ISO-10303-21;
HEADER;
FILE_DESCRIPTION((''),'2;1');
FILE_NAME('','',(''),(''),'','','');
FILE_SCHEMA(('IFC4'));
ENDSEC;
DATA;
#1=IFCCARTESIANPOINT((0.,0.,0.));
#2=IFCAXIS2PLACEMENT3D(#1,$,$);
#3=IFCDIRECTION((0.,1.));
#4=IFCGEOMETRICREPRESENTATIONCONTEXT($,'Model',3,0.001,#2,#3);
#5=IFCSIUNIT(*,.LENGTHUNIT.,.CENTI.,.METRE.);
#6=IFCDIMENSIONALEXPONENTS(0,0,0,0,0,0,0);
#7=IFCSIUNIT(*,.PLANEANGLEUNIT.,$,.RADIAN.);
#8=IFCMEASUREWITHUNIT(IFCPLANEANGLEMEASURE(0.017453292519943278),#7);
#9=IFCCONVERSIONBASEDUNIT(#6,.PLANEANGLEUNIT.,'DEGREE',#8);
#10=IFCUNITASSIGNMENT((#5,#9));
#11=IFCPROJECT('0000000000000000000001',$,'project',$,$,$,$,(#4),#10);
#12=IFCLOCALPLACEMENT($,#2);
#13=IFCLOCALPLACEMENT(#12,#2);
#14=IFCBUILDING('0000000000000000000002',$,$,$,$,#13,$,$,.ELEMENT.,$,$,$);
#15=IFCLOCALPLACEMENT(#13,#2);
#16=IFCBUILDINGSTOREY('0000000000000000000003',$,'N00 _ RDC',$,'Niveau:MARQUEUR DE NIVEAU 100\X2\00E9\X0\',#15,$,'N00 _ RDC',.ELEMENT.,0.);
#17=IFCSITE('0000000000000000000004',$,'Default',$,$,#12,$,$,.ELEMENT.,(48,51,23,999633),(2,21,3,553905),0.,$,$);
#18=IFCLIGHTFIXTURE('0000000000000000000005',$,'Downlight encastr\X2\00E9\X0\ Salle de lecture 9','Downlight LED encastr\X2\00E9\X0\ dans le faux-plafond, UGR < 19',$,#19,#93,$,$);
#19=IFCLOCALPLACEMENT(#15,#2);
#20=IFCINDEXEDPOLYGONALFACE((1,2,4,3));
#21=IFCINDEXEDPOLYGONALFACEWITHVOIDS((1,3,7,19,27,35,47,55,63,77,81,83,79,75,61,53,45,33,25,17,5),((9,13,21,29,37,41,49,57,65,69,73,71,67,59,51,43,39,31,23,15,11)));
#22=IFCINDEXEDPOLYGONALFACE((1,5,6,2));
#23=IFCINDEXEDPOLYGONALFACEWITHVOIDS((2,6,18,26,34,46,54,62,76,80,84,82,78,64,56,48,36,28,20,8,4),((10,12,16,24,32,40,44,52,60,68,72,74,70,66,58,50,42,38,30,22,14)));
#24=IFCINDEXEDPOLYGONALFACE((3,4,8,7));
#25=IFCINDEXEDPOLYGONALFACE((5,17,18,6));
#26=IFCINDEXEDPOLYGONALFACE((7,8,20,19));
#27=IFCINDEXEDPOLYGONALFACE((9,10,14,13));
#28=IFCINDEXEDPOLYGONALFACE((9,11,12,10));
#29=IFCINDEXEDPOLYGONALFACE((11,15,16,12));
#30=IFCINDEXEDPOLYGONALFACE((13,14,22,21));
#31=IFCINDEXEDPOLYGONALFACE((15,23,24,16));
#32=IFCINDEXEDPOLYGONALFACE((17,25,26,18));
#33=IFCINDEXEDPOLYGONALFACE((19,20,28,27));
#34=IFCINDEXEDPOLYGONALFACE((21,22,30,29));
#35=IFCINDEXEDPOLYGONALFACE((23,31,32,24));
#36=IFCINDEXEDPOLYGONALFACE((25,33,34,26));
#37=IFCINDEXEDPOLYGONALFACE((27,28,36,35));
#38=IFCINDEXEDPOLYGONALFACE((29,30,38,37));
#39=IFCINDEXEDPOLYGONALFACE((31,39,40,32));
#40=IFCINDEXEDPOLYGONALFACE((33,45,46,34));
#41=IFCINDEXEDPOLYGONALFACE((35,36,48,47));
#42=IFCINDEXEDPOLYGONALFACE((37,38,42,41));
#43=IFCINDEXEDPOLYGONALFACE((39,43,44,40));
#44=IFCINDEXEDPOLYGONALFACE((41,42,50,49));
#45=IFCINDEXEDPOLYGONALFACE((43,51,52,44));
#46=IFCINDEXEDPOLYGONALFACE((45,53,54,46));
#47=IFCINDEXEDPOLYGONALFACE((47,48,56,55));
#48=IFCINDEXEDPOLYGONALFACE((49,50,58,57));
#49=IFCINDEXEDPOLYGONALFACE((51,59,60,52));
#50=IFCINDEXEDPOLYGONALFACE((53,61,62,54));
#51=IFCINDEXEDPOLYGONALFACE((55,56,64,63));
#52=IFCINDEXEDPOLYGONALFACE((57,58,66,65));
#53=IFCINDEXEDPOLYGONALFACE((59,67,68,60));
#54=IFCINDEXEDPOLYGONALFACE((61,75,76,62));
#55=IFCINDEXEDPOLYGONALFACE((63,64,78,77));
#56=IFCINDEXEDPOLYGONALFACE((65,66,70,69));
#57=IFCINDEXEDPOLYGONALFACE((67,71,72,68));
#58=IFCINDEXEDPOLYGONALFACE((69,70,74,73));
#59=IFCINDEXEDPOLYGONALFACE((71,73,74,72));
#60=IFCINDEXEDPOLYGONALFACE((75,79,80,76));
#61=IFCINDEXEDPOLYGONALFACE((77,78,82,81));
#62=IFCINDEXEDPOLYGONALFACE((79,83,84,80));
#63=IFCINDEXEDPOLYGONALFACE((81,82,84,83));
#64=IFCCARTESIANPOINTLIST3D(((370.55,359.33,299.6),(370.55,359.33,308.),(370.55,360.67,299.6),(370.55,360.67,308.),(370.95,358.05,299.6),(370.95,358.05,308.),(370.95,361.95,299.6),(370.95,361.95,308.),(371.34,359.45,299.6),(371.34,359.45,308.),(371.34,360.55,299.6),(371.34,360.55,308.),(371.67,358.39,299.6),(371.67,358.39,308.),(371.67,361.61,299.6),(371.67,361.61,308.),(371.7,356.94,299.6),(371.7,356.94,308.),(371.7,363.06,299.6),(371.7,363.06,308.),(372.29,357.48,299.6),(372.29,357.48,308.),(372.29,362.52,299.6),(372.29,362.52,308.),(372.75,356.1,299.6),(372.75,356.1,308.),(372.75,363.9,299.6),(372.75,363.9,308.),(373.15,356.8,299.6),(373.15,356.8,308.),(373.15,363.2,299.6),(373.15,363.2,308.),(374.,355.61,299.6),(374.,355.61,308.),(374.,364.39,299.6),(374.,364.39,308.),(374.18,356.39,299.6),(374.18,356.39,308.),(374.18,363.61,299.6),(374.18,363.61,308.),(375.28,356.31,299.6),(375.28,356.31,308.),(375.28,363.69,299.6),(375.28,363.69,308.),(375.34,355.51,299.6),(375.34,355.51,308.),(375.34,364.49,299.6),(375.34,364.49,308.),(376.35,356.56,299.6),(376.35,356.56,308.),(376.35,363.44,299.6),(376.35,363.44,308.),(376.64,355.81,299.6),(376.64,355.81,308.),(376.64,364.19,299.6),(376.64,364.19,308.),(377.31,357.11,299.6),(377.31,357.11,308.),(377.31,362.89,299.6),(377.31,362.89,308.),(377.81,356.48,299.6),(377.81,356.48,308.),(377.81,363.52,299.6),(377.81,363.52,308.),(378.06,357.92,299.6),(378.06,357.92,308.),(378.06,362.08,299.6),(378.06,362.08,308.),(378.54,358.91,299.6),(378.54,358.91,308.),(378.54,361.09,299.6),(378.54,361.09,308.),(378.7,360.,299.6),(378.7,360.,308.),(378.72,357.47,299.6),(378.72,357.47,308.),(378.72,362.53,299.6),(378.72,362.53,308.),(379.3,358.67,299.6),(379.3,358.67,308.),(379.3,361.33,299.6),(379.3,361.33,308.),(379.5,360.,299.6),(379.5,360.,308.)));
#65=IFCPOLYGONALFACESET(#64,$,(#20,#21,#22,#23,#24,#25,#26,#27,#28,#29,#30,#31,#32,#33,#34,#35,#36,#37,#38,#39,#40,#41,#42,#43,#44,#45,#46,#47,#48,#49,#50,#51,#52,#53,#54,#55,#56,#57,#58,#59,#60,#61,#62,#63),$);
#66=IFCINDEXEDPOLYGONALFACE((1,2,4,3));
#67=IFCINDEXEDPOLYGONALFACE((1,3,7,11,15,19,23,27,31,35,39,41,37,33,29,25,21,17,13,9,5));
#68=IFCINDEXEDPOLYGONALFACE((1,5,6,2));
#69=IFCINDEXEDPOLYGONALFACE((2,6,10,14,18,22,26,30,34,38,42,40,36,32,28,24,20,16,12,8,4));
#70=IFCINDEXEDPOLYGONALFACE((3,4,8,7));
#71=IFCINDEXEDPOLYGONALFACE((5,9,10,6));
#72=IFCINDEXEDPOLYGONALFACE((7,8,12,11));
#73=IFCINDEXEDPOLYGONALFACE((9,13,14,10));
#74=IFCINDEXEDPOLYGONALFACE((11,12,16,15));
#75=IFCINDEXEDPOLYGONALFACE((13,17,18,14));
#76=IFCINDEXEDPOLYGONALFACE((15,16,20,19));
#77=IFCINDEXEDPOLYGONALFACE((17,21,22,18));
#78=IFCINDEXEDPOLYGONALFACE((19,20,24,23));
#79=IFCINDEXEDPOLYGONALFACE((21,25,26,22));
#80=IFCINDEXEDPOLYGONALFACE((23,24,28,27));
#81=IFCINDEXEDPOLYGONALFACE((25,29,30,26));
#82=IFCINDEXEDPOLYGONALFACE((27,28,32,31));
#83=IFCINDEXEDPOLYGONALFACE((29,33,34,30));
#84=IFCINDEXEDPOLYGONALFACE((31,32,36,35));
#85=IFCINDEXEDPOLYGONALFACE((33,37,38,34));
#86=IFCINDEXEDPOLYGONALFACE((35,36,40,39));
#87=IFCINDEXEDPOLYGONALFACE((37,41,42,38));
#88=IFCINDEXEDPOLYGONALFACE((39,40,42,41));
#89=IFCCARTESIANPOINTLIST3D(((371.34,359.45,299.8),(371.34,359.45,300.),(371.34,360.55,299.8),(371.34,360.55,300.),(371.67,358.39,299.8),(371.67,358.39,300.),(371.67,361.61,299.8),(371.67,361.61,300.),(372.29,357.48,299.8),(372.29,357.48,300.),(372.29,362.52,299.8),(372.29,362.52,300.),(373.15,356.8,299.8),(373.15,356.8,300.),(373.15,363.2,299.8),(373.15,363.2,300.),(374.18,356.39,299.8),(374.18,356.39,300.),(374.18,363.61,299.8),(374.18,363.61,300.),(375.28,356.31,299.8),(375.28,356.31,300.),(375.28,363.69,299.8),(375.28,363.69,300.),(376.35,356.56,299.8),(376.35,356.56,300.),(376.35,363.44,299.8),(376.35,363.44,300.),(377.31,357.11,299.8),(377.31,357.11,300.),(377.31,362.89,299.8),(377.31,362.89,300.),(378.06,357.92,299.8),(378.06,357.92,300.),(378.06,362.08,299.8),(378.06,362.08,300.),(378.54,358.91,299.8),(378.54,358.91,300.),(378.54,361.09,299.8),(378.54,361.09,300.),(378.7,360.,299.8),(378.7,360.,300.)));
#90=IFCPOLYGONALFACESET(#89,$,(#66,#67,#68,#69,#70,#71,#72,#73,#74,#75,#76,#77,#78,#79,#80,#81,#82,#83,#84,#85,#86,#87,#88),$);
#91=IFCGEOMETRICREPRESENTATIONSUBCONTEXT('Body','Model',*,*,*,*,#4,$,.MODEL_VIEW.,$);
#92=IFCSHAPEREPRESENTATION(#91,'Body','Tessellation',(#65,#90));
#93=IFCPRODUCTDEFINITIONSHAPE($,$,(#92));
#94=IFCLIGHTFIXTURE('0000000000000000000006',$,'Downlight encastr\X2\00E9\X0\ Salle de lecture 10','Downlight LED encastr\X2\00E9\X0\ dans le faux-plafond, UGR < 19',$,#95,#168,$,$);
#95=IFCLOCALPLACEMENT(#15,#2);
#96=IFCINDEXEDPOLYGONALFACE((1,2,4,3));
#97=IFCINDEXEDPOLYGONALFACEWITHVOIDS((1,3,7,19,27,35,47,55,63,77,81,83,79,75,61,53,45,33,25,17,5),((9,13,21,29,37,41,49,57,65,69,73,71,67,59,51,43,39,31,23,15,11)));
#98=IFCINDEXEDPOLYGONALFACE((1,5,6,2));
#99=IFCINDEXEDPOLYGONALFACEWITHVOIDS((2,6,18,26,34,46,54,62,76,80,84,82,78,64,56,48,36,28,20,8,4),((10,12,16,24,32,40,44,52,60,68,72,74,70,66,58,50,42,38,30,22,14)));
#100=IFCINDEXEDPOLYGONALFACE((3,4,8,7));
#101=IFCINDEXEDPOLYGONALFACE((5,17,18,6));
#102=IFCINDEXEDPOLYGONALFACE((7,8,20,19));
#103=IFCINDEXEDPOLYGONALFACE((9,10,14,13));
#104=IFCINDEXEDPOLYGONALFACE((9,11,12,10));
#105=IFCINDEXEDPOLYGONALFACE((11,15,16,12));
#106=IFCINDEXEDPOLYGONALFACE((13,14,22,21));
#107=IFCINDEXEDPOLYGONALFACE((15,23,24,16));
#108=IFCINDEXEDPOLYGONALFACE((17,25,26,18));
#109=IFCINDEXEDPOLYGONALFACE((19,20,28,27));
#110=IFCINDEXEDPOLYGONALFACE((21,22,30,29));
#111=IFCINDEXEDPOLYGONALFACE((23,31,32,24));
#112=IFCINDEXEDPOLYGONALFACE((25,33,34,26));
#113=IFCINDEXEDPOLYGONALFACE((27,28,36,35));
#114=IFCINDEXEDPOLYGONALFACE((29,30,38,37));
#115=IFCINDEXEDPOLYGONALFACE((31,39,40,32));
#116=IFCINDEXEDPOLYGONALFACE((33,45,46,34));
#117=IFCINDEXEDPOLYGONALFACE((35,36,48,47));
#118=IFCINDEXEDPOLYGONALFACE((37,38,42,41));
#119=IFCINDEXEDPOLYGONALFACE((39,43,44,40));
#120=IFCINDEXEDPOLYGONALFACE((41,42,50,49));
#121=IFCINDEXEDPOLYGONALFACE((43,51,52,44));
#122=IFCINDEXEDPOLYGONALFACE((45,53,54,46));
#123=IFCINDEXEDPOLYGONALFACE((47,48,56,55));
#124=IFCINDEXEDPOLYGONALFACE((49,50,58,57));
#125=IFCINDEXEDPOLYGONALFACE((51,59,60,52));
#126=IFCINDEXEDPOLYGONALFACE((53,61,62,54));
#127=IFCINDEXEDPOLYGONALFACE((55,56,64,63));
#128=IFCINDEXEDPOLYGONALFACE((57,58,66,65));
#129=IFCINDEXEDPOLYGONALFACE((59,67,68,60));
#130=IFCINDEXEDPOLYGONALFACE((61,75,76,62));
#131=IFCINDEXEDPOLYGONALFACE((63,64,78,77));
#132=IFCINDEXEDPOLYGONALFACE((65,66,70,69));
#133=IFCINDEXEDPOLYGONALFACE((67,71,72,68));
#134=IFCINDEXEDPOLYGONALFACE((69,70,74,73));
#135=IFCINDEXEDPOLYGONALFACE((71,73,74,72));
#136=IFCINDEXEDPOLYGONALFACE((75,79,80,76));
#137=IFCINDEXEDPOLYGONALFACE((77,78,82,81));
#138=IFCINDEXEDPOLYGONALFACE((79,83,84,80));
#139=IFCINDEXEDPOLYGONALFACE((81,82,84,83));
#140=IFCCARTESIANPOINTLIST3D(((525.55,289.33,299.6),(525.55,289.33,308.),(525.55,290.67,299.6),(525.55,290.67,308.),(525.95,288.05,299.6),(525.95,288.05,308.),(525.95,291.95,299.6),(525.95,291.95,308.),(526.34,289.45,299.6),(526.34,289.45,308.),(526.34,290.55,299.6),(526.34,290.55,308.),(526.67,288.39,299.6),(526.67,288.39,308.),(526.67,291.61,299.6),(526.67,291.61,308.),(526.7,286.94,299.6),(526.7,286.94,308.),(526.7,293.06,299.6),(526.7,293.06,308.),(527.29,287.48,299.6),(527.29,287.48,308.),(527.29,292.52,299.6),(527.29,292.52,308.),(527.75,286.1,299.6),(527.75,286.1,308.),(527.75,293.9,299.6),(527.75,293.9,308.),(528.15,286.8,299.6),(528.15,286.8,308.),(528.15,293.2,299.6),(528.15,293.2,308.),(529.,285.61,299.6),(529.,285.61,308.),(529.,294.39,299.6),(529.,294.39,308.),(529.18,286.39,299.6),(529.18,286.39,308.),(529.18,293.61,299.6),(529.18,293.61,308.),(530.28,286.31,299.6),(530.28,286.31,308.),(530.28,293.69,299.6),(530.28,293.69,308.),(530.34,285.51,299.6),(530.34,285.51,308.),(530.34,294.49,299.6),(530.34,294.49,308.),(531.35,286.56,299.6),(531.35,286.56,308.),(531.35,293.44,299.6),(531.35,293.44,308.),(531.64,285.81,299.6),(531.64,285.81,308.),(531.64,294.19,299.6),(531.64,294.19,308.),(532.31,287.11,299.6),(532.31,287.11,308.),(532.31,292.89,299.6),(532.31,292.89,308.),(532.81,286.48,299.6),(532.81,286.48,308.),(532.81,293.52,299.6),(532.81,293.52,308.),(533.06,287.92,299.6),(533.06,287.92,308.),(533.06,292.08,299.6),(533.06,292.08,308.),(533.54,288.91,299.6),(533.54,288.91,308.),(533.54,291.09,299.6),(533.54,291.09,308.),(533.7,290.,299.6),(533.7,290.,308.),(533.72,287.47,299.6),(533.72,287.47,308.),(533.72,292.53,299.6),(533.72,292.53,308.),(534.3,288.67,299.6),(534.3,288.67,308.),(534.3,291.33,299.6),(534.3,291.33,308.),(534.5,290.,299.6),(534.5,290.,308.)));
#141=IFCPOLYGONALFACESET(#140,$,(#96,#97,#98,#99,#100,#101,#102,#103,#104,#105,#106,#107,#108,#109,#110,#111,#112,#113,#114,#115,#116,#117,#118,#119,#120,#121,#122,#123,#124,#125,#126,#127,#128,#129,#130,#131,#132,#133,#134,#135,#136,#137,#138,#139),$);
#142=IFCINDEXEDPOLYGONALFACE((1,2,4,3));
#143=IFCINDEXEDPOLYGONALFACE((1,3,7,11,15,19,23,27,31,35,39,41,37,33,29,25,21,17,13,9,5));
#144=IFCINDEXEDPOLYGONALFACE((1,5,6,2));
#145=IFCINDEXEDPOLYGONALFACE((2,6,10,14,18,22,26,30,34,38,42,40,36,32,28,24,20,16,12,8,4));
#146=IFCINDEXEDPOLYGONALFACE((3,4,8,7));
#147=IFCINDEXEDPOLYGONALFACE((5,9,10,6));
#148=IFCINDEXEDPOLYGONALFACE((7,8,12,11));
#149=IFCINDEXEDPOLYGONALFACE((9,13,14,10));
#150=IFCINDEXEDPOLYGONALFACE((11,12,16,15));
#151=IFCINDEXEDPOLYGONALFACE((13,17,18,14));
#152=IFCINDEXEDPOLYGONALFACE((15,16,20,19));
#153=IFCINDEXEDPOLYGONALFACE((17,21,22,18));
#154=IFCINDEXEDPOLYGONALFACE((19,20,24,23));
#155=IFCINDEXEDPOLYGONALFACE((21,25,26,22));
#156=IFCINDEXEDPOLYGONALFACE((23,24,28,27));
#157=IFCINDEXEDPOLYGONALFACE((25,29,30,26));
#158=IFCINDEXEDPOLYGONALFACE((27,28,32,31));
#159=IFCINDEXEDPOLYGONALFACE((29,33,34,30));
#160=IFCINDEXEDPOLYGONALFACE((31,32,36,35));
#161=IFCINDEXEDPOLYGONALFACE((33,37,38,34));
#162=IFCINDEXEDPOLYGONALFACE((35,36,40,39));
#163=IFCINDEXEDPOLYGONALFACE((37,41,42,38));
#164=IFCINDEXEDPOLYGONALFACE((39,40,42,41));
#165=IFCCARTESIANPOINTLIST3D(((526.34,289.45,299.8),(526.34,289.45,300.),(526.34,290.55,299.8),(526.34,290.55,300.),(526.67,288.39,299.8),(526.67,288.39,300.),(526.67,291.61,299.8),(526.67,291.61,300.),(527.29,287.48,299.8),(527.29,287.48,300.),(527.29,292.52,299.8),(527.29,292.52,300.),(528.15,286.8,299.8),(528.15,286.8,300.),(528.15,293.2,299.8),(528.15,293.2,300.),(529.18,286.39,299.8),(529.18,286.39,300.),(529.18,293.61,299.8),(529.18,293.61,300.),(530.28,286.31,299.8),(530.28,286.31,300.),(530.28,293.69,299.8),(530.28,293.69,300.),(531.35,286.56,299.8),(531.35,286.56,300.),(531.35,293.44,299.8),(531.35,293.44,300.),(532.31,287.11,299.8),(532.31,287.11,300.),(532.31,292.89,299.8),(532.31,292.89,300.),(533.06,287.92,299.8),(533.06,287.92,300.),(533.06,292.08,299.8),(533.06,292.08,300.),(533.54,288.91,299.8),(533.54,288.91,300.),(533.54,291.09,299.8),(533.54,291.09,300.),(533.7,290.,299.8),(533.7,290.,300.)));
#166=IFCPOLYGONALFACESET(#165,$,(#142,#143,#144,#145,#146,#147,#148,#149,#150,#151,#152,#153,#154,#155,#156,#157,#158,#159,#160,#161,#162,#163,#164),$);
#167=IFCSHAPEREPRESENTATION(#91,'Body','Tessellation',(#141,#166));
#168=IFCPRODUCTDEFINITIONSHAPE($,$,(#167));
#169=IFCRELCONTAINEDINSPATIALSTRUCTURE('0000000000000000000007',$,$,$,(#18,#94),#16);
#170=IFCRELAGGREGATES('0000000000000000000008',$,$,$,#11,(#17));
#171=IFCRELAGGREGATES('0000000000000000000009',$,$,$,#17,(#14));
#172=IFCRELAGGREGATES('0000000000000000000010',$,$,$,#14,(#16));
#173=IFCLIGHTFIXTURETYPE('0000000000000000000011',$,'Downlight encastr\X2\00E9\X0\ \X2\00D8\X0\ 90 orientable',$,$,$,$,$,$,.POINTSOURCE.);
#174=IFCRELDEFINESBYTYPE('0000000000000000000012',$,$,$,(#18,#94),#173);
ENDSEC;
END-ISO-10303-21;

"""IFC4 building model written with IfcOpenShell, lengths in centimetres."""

from ifc_helpers import new_model, entity, si_unit, converted_unit, direction, frame, frame_2d, origin, origin_with_axes, place, context, subcontext, project, spatial, circle, hollow_circle, extrude, type_object, element, save


model = new_model("IFC4")

# Units and contexts
model_context = context("Model", 3, precision=0.001, world=origin(), true_north=direction((0.0, 1.0)))
body_context = subcontext(model_context, "Body", "Model", "MODEL_VIEW")
ifc_project = project(units=[si_unit("LENGTHUNIT", "METRE", prefix="CENTI"), converted_unit("PLANEANGLEUNIT", "DEGREE", entity("IfcPlaneAngleMeasure", 0.017453292519943278), si_unit("PLANEANGLEUNIT", "RADIAN"), dimensions=[0, 0, 0, 0, 0, 0, 0])], contexts=[model_context])

# Site, building, storey
site_placement = place(None, origin())
site = spatial("IfcSite", under=ifc_project, at=site_placement, Name="Default", CompositionType="ELEMENT", RefLatitude=(48, 51, 23, 999633), RefLongitude=(2, 21, 3, 553905), RefElevation=0.0)
building_placement = place(site_placement, origin())
building = spatial("IfcBuilding", under=site, at=building_placement, CompositionType="ELEMENT")
storey_placement = place(building_placement, origin())
storey = spatial("IfcBuildingStorey", under=building, at=storey_placement, Name="N00 _ RDC", ObjectType="Niveau:MARQUEUR DE NIVEAU 100é", LongName="N00 _ RDC", CompositionType="ELEMENT", Elevation=0.0)

# Light fixtures
light_fixture_type_1 = type_object("IfcLightFixtureType", Name="Downlight encastré Ø 90 orientable", PredefinedType="POINTSOURCE")
light_fixture_1_placement = place(storey_placement, origin_with_axes())
element("IfcLightFixture", 1, at=light_fixture_1_placement, inside=storey, type_object=light_fixture_type_1, Name="Downlight encastré Salle de lecture 9", Description="Downlight LED encastré dans le faux-plafond, UGR < 19", context=body_context, shape_type="SweptSolid", body=[
    extrude(hollow_circle(Radius=4.5, WallThickness=0.8, at=frame_2d((375.0, 360.0))), frame((0.0, 0.0, 299.6)), (0.0, 0.0, 1.0), 8.4),
    extrude(circle(Radius=3.7, at=frame_2d((375.0, 360.0))), frame((0.0, 0.0, 299.8)), (0.0, 0.0, 1.0), 0.2),
])
light_fixture_2_placement = place(storey_placement, origin_with_axes())
element("IfcLightFixture", 2, at=light_fixture_2_placement, inside=storey, type_object=light_fixture_type_1, Name="Downlight encastré Salle de lecture 10", Description="Downlight LED encastré dans le faux-plafond, UGR < 19", context=body_context, shape_type="SweptSolid", body=[
    extrude(hollow_circle(Radius=4.5, WallThickness=0.8, at=frame_2d((530.0, 290.0))), frame((0.0, 0.0, 299.6)), (0.0, 0.0, 1.0), 8.4),
    extrude(circle(Radius=3.7, at=frame_2d((530.0, 290.0))), frame((0.0, 0.0, 299.8)), (0.0, 0.0, 1.0), 0.2),
])

save(model, "model.ifc")
